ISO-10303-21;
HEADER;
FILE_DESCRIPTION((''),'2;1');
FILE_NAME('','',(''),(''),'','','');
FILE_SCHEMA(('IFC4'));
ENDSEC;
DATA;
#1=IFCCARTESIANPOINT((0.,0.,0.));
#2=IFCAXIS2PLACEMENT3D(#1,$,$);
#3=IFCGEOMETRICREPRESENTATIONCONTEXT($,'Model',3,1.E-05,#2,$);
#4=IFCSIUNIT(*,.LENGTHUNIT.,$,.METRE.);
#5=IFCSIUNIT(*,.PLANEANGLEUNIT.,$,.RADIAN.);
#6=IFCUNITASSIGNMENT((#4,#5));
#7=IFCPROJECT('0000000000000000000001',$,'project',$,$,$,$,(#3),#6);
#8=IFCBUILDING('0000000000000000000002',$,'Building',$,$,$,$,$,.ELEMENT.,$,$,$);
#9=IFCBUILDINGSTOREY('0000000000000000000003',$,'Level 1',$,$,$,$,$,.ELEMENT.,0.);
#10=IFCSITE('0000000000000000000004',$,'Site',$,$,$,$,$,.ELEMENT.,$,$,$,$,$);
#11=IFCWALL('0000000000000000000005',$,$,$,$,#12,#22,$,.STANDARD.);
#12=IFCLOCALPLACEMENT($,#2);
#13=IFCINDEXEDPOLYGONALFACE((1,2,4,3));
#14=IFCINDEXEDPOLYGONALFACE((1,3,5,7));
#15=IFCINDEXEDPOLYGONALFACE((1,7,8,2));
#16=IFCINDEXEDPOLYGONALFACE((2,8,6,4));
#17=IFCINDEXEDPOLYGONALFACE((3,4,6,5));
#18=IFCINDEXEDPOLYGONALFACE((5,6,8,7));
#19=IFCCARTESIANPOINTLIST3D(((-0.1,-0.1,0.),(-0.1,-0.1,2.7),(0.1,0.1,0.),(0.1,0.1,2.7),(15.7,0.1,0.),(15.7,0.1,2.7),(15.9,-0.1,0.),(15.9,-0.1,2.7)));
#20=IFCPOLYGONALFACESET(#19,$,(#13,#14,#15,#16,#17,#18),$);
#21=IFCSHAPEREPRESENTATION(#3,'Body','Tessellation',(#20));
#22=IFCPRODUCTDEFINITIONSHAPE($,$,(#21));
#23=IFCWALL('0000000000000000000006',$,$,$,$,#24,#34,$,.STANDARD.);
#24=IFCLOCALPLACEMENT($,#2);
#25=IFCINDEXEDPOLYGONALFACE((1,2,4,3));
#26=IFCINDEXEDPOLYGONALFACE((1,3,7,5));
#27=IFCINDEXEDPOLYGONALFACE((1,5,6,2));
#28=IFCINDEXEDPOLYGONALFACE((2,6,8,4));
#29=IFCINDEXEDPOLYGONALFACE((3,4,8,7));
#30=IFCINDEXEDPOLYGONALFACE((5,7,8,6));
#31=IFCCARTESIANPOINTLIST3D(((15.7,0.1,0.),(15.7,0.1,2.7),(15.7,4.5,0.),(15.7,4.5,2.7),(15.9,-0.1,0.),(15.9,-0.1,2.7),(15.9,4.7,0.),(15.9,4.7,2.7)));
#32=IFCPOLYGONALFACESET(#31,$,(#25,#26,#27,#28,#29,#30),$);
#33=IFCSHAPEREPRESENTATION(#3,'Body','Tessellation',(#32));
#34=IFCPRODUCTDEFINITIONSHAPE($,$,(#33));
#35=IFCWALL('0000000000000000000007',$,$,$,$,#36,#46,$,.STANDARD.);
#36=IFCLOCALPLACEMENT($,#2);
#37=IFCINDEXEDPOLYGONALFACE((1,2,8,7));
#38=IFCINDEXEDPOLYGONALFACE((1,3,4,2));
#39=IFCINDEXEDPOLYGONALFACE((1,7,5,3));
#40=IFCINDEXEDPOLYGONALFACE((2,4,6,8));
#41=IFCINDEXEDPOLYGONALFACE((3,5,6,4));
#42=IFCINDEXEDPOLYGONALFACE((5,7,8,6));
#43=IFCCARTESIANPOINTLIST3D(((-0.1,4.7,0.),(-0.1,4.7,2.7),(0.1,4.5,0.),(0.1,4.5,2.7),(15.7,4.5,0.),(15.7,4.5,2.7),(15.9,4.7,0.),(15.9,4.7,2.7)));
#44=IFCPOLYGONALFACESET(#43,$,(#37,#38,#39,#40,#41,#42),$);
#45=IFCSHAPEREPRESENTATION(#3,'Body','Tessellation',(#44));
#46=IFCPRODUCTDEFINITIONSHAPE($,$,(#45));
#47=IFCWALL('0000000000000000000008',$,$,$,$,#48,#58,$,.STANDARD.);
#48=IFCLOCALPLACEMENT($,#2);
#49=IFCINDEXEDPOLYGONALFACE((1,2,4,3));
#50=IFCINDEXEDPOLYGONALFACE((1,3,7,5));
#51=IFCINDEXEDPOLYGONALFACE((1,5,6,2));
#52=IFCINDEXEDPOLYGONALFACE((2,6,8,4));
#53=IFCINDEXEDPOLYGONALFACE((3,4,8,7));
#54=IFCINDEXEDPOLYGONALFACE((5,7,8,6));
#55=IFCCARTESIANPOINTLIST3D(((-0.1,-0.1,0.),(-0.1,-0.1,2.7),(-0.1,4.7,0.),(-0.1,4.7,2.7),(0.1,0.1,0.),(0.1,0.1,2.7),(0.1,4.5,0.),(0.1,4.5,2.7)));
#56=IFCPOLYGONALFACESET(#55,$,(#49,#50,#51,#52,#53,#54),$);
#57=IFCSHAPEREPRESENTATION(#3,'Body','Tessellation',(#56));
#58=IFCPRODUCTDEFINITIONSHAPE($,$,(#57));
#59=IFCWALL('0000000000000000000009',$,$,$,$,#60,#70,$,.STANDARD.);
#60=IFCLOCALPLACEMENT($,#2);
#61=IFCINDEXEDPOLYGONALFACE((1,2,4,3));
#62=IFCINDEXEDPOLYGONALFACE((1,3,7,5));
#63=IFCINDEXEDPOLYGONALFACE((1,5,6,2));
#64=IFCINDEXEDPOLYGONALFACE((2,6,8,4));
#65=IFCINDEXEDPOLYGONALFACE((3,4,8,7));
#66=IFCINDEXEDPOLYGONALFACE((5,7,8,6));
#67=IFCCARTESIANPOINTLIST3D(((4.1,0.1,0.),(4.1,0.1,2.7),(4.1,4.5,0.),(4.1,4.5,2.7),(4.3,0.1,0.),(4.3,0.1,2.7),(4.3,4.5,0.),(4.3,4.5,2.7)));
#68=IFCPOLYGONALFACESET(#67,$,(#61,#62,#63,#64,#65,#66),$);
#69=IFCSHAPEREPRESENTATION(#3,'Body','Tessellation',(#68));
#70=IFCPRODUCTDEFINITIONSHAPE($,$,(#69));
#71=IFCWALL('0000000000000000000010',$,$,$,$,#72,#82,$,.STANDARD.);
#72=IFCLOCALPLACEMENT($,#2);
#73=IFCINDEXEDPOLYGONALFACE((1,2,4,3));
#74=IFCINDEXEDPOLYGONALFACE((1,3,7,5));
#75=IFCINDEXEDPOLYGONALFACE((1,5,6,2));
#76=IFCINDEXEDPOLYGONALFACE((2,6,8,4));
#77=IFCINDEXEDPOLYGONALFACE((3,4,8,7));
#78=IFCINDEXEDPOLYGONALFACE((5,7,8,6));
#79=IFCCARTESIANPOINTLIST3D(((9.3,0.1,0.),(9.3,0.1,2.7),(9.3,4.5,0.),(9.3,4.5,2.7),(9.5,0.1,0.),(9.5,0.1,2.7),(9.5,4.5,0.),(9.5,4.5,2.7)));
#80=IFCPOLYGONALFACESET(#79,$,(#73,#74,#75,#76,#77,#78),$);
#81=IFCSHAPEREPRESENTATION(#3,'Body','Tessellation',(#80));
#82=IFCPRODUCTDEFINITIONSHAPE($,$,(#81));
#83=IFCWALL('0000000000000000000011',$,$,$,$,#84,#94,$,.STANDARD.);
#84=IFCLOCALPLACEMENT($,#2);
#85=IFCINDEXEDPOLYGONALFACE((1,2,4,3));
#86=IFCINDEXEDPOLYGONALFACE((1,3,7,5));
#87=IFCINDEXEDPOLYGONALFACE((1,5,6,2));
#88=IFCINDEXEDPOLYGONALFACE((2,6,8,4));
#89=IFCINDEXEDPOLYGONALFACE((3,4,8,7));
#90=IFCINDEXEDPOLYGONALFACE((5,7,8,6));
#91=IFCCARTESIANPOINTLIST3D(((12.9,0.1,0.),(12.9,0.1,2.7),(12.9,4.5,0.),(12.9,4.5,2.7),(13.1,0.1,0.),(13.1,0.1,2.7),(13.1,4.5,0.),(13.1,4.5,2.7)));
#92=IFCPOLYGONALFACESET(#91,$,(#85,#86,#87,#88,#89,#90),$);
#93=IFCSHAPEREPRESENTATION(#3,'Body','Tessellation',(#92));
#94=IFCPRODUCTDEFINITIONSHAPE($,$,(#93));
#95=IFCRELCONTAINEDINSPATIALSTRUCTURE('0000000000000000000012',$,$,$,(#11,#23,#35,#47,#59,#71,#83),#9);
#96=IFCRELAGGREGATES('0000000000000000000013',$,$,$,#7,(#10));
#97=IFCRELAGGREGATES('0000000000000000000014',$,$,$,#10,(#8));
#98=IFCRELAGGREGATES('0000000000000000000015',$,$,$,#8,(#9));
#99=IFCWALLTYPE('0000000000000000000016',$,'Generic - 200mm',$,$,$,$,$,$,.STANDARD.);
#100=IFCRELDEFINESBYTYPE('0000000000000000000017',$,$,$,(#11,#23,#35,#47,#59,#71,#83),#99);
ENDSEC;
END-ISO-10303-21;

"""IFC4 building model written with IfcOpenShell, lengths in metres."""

from ifc_helpers import new_model, si_unit, frame, frame_2d, origin, origin_with_axes, place, context, project, spatial, polyline, rectangle, outline, extrude, type_object, element, save


model = new_model("IFC4")

# Units and contexts
model_context = context("Model", 3, precision=1e-05, world=origin())
ifc_project = project(units=[si_unit("LENGTHUNIT", "METRE"), si_unit("PLANEANGLEUNIT", "RADIAN")], contexts=[model_context])

# Site, building, storey
site = spatial("IfcSite", under=ifc_project, Name="Site", CompositionType="ELEMENT")
building = spatial("IfcBuilding", under=site, Name="Building", CompositionType="ELEMENT")
storey = spatial("IfcBuildingStorey", under=building, Name="Level 1", CompositionType="ELEMENT", Elevation=0.0)

# Walls
wall_type = type_object("IfcWallType", Name="Generic - 200mm", PredefinedType="STANDARD")
wall_1_placement = place(None, origin_with_axes())
element("IfcWall", 1, at=wall_1_placement, inside=storey, type_object=wall_type, PredefinedType="STANDARD", context=model_context, shape_type="SweptSolid", body=[
    extrude(outline(polyline([(-0.1, -0.1), (15.9, -0.1), (15.7, 0.1), (0.1, 0.1), (-0.1, -0.1)])), origin(), (0.0, 0.0, 1.0), 2.7),
])
wall_2_placement = place(None, frame((15.8, 0.0, 0.0), z_axis=(0.0, 0.0, 1.0), x_axis=(0.0, 1.0, 0.0)))
element("IfcWall", 2, at=wall_2_placement, inside=storey, type_object=wall_type, PredefinedType="STANDARD", context=model_context, shape_type="SweptSolid", body=[
    extrude(outline(polyline([(-0.1, -0.1), (4.7, -0.1), (4.5, 0.1), (0.1, 0.1), (-0.1, -0.1)])), origin(), (0.0, 0.0, 1.0), 2.7),
])
wall_3_placement = place(None, frame((15.8, 4.6, 0.0), z_axis=(0.0, 0.0, 1.0), x_axis=(-1.0, 0.0, 0.0)))
element("IfcWall", 3, at=wall_3_placement, inside=storey, type_object=wall_type, PredefinedType="STANDARD", context=model_context, shape_type="SweptSolid", body=[
    extrude(outline(polyline([(-0.1, -0.1), (15.9, -0.1), (15.7, 0.1), (0.1, 0.1), (-0.1, -0.1)])), origin(), (0.0, 0.0, 1.0), 2.7),
])
wall_4_placement = place(None, frame((0.0, 4.6, 0.0), z_axis=(0.0, 0.0, 1.0), x_axis=(0.0, -1.0, 0.0)))
element("IfcWall", 4, at=wall_4_placement, inside=storey, type_object=wall_type, PredefinedType="STANDARD", context=model_context, shape_type="SweptSolid", body=[
    extrude(outline(polyline([(-0.1, -0.1), (4.7, -0.1), (4.5, 0.1), (0.1, 0.1), (-0.1, -0.1)])), origin(), (0.0, 0.0, 1.0), 2.7),
])
for number, where, z_axis, x_axis in (
    (5, (4.2, 0.1, 0.0), (0.0, 0.0, 1.0), (0.0, 1.0, 0.0)),
    (6, (9.4, 0.1, 0.0), (0.0, 0.0, 1.0), (0.0, 1.0, 0.0)),
    (7, (13.0, 0.1, 0.0), (0.0, 0.0, 1.0), (0.0, 1.0, 0.0)),
):
    element("IfcWall", number, at=place(None, frame(where, z_axis=z_axis, x_axis=x_axis)), inside=storey, type_object=wall_type, PredefinedType="STANDARD", context=model_context, shape_type="SweptSolid", body=[
        extrude(rectangle(XDim=4.4, YDim=0.2, at=frame_2d((2.2, 0.0))), origin(), (0.0, 0.0, 1.0), 2.7),
    ])

save(model, "model.ifc")
